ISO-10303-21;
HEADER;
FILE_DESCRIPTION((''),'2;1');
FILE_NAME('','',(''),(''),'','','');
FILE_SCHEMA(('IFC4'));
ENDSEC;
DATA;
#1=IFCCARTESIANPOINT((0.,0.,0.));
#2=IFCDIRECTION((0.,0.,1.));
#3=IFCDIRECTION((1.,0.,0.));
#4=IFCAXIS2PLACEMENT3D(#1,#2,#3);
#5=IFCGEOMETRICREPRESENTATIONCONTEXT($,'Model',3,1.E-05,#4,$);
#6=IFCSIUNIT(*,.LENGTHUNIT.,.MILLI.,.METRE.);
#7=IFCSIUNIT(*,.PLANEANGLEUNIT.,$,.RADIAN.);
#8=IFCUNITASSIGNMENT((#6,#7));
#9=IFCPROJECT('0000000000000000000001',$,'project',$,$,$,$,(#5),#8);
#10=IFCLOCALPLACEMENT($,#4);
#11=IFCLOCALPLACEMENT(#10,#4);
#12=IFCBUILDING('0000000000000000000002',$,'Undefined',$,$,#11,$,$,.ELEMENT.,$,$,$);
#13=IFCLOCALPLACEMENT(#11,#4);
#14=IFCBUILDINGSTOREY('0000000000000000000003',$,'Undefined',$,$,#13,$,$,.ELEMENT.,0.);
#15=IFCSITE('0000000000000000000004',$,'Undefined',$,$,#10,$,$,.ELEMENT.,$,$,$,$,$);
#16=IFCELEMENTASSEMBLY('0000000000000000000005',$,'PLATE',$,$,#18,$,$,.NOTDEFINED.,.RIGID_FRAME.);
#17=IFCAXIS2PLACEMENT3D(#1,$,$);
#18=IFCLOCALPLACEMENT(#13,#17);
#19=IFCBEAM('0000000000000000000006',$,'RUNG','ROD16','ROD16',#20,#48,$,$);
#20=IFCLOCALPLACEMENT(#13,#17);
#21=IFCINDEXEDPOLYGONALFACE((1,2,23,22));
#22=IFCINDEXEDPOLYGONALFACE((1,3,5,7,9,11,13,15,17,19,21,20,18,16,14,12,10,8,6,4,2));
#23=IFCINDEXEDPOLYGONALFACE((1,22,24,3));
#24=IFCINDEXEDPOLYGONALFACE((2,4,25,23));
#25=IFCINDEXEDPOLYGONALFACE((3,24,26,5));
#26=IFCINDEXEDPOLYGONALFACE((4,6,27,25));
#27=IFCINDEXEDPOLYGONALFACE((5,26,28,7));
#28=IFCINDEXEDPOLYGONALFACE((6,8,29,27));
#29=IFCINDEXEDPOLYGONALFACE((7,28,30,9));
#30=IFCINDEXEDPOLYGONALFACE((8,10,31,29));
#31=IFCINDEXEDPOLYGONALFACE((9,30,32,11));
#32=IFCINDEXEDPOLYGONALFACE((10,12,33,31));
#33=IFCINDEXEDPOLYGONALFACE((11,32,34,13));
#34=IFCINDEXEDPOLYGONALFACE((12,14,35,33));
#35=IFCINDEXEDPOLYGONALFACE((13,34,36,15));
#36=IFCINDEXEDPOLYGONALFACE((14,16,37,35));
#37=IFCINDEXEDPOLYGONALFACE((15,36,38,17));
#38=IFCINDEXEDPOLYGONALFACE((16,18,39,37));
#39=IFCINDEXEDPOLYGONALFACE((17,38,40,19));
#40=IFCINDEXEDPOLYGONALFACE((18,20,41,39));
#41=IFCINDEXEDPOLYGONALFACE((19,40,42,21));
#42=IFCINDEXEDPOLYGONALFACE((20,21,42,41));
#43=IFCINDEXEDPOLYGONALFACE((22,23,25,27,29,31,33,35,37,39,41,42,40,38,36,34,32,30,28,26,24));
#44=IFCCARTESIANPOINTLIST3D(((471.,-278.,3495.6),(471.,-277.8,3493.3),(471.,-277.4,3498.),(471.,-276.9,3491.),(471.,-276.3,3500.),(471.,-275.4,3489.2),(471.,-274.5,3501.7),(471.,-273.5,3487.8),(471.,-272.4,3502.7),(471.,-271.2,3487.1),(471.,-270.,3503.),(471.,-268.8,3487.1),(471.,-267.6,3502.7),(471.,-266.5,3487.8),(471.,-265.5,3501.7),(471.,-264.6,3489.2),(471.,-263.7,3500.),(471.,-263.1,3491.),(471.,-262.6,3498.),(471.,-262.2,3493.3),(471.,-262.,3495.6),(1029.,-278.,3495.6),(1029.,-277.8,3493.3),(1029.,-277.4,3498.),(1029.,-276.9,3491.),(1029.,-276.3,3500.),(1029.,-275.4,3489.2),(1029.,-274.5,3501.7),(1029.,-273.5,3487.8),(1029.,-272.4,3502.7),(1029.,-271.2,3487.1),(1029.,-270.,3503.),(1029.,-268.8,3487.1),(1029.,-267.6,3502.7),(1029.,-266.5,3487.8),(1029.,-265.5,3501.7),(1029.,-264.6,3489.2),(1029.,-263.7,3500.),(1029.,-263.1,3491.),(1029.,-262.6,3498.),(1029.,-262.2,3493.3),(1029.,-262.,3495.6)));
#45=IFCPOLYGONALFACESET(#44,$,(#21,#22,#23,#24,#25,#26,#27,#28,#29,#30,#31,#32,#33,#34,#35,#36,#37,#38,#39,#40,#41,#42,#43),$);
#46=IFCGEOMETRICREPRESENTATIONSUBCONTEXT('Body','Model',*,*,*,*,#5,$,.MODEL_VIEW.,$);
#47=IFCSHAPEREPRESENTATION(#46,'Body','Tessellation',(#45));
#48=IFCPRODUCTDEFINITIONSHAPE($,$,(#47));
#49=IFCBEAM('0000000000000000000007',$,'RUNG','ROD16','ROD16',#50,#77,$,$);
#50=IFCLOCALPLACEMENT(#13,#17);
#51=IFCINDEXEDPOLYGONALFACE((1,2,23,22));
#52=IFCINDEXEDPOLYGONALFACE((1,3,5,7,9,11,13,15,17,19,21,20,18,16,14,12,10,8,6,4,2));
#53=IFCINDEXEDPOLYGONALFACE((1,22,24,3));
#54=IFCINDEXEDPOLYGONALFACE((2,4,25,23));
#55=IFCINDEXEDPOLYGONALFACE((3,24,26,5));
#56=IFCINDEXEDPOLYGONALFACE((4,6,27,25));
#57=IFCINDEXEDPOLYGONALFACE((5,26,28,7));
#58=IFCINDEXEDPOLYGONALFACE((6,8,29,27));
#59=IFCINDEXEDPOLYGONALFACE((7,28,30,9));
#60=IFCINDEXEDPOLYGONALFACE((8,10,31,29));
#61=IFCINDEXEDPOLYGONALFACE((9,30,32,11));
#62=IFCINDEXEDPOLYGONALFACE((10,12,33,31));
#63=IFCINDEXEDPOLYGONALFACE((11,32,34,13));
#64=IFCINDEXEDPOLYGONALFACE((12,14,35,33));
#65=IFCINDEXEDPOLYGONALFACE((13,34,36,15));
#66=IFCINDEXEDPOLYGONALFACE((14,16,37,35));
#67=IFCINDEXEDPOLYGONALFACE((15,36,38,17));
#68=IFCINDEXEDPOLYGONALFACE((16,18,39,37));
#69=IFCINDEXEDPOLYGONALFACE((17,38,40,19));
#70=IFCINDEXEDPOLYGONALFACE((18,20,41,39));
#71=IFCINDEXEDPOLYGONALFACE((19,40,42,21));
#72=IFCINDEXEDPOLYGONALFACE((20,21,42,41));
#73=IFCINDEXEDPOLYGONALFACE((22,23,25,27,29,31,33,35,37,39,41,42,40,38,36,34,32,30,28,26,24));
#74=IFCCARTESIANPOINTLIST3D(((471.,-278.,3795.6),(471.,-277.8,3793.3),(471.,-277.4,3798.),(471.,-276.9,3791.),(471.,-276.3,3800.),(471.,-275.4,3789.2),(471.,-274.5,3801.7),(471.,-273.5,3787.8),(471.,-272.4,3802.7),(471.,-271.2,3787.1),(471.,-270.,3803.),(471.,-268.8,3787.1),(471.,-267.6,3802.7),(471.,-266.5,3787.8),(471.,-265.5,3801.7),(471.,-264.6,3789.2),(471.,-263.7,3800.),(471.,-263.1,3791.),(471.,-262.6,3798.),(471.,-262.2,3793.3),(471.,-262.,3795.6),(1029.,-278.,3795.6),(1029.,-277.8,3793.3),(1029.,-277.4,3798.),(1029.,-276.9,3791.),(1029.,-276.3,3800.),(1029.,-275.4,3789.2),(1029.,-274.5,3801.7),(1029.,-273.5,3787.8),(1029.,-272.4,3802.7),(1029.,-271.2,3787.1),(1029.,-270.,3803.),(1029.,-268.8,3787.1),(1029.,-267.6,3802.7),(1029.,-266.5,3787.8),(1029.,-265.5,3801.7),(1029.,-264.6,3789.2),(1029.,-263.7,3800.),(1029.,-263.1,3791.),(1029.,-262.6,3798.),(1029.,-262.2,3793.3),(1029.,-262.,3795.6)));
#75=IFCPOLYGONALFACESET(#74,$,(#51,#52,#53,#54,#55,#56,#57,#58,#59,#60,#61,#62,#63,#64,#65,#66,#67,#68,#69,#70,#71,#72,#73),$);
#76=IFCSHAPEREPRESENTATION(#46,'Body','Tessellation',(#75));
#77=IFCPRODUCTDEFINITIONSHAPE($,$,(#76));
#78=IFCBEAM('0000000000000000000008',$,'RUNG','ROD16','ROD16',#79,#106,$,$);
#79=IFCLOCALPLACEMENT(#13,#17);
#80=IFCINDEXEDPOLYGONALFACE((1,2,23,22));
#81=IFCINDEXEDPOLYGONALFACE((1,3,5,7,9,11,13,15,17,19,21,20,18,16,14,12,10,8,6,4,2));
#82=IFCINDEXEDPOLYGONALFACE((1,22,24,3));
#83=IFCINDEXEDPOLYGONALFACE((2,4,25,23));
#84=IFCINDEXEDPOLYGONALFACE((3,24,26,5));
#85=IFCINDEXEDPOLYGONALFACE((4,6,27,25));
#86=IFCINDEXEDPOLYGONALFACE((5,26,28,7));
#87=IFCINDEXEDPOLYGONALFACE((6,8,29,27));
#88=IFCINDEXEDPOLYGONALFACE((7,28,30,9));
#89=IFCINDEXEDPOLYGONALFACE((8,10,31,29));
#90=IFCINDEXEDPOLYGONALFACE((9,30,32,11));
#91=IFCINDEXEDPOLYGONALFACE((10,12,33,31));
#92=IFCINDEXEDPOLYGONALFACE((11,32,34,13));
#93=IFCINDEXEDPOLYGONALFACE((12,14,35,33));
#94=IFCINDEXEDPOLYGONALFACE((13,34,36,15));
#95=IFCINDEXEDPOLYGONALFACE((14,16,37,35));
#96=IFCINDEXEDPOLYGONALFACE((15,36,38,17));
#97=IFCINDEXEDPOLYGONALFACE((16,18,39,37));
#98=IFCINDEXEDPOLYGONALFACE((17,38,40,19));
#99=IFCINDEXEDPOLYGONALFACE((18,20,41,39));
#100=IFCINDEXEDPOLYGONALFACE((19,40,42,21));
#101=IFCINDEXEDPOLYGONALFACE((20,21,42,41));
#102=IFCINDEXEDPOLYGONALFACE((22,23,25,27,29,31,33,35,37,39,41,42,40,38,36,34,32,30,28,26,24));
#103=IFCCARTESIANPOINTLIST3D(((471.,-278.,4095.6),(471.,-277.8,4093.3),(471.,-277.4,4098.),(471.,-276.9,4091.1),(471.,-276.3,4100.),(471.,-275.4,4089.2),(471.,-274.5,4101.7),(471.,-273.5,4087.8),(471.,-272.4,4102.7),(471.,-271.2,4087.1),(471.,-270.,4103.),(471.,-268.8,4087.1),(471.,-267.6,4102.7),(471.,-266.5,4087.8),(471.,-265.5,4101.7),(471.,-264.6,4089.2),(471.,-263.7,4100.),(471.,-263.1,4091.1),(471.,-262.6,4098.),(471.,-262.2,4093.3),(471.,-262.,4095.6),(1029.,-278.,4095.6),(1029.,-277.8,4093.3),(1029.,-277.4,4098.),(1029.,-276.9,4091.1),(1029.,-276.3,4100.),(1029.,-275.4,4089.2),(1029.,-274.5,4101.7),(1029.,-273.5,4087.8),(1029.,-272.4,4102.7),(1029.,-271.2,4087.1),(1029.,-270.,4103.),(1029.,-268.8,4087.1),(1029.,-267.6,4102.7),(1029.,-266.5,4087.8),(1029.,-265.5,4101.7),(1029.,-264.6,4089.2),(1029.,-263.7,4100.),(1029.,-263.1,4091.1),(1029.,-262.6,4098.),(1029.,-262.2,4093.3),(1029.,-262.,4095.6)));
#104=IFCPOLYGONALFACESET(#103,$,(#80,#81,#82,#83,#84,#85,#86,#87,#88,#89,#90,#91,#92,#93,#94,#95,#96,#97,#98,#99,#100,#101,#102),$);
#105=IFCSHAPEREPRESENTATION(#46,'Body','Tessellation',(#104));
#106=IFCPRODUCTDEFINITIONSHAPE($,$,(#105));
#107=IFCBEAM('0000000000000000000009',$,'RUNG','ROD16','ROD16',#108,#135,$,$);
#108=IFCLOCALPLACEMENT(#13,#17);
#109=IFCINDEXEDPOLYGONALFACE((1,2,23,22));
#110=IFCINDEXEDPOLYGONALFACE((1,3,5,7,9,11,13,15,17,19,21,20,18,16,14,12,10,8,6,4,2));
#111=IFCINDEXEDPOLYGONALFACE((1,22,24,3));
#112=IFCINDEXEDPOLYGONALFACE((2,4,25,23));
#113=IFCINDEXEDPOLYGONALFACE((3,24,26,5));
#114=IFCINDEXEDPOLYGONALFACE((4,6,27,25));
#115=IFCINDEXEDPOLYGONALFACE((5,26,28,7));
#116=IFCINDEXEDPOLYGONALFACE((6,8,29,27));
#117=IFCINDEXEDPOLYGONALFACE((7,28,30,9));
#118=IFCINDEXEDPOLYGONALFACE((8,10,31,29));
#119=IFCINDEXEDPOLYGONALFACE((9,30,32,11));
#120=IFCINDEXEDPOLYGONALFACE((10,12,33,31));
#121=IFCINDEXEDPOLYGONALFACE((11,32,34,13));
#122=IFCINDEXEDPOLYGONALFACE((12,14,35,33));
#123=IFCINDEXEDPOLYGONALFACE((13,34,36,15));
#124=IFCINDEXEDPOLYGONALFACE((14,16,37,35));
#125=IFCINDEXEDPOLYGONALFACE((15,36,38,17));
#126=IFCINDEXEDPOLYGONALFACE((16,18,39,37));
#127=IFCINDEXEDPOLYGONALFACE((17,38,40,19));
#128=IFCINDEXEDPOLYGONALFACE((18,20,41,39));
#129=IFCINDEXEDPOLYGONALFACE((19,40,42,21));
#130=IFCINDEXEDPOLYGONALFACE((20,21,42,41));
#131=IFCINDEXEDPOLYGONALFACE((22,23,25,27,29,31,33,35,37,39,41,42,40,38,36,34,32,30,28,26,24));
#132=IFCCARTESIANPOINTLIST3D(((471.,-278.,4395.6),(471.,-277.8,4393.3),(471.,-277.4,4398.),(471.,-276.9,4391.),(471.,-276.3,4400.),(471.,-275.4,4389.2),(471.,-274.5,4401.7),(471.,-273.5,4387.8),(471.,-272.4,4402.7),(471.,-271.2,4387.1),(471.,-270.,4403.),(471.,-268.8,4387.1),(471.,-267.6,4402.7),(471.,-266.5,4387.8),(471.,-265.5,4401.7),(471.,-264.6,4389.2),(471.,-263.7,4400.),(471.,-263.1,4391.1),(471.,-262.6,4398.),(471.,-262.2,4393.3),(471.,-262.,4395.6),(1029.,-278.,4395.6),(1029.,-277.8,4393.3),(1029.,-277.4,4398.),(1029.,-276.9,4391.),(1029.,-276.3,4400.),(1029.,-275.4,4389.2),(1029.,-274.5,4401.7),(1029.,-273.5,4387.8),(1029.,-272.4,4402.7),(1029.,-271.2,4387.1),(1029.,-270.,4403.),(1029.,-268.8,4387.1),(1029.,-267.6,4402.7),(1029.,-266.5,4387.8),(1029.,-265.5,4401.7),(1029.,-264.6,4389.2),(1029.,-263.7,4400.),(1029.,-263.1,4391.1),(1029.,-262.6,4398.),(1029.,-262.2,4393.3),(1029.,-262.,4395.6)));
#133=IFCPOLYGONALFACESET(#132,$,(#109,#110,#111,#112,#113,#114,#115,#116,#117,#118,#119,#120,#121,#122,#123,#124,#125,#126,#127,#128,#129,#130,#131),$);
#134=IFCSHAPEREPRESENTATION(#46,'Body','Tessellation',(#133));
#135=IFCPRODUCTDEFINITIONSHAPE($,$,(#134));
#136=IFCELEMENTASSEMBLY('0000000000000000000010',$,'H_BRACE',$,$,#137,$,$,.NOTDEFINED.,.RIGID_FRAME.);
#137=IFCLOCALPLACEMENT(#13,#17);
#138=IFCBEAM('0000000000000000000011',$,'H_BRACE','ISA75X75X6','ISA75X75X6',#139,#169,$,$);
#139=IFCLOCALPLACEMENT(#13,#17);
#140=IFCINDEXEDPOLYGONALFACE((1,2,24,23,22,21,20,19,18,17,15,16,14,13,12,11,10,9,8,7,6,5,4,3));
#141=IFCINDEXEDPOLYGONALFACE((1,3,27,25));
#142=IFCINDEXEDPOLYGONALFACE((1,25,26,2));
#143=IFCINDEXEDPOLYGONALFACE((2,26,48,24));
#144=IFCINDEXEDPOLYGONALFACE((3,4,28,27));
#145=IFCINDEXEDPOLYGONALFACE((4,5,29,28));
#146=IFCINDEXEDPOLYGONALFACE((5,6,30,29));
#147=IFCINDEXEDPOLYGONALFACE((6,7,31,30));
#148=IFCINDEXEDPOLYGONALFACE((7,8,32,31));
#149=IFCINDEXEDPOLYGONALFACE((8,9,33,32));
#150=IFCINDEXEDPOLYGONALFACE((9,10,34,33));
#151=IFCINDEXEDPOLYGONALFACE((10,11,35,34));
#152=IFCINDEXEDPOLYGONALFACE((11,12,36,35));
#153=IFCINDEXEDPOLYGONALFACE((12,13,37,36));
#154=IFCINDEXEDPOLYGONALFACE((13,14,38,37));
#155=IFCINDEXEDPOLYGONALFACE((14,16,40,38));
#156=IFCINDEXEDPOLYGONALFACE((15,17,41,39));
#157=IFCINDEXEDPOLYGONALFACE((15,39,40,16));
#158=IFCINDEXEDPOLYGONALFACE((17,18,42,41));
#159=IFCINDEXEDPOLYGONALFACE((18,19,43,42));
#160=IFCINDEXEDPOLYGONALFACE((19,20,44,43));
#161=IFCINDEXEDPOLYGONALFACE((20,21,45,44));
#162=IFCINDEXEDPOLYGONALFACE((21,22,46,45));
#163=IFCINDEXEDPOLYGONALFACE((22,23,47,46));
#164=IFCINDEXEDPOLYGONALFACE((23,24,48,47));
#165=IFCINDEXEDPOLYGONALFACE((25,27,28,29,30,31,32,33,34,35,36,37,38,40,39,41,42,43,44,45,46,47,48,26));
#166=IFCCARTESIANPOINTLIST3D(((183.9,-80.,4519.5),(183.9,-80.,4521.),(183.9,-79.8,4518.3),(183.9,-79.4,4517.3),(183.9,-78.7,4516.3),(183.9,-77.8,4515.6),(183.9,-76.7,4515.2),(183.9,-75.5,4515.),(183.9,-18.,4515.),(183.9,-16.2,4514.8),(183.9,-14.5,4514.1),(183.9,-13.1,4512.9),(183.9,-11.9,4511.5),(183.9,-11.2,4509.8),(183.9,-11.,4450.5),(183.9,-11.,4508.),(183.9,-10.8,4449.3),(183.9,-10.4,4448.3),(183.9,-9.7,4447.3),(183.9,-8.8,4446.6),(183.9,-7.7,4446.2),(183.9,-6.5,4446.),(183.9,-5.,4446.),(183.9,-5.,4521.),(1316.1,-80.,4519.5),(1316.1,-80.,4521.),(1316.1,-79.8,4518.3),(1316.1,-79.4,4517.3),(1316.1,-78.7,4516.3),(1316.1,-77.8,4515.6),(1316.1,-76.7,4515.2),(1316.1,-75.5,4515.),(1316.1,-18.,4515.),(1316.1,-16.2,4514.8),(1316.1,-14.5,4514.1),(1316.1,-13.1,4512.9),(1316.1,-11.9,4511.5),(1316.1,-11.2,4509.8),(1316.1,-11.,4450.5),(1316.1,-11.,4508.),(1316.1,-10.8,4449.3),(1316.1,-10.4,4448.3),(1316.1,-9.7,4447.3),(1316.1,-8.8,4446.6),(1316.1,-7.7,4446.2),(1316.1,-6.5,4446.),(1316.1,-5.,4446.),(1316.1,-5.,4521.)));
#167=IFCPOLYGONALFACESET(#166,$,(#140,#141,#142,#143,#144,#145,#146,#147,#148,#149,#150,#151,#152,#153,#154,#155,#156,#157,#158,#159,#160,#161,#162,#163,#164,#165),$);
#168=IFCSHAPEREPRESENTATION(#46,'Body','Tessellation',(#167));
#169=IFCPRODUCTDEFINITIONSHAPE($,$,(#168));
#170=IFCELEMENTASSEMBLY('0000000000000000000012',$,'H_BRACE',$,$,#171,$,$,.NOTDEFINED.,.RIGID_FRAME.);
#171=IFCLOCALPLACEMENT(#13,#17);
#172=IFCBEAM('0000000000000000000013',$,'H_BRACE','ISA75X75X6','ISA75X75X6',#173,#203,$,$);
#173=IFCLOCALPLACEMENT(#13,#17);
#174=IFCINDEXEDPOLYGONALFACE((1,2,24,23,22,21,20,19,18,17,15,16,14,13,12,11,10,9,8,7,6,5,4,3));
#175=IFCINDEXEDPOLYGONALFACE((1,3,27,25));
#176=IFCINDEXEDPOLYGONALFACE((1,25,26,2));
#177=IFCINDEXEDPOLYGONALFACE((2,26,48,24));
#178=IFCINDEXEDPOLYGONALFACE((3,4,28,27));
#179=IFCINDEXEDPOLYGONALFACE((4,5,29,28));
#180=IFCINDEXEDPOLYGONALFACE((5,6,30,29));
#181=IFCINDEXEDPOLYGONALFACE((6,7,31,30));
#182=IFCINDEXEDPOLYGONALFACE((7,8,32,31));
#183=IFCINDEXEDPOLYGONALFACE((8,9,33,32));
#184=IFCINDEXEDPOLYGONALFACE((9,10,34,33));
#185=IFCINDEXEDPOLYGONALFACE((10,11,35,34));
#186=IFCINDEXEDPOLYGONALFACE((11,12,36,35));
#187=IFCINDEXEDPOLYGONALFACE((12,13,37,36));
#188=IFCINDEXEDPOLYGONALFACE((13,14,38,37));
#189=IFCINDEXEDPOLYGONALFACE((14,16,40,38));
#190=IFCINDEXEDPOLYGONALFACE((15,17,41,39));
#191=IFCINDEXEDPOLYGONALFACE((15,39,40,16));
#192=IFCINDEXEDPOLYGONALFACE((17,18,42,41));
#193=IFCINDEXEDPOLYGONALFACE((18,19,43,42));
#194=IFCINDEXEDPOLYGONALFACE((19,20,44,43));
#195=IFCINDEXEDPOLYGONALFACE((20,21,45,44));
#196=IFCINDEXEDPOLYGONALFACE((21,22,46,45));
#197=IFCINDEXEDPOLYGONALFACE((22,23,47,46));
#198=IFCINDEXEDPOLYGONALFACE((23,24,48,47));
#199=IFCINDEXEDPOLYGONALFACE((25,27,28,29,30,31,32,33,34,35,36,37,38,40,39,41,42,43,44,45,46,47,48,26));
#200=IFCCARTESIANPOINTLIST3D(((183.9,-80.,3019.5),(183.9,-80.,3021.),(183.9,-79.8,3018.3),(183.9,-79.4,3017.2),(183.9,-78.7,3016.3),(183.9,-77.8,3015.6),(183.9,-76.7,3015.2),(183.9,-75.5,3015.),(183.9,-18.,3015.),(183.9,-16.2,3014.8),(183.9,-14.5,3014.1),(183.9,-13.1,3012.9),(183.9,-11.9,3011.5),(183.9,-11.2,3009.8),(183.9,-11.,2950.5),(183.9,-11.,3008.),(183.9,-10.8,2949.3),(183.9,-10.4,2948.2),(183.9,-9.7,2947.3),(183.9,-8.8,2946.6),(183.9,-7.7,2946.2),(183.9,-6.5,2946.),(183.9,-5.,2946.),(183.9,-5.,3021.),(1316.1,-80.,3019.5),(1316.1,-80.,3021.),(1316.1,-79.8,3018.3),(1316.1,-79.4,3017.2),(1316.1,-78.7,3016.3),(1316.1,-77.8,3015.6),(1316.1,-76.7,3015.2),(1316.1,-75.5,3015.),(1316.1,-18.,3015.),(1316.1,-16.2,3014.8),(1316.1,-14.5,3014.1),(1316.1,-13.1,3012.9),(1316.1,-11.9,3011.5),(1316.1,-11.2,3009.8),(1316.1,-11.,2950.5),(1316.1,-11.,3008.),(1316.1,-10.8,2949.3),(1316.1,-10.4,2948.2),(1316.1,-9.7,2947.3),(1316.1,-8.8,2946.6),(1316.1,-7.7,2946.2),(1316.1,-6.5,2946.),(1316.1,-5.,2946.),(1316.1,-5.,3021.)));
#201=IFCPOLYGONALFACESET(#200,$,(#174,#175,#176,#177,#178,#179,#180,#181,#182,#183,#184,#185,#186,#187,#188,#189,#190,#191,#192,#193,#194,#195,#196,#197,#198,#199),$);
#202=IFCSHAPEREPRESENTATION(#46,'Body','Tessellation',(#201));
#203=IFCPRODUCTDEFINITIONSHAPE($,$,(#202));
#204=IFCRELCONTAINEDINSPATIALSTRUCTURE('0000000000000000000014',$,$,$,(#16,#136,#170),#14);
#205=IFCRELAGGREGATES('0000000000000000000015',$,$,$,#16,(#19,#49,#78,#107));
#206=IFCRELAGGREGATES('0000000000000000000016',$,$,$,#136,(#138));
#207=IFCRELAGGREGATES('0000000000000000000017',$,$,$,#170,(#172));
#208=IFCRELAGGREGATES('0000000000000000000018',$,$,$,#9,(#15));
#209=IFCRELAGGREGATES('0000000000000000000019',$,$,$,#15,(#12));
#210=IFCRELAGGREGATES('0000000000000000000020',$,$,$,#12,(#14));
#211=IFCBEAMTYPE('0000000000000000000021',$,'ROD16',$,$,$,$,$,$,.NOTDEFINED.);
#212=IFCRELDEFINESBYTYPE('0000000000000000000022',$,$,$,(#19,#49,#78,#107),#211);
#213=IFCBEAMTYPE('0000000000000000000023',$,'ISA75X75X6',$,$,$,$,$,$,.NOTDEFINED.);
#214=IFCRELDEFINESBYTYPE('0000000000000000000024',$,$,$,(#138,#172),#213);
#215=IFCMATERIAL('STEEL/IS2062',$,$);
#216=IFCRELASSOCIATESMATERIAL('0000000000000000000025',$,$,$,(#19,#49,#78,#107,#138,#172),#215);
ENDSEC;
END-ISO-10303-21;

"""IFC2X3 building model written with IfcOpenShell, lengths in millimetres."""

from ifc_helpers import new_model, si_unit, frame, origin_with_axes, origin_2d_with_axis, place, context, subcontext, project, spatial, circle, l_section, extrude, clip, halfspace, material, type_object, element, aggregate, save


model = new_model("IFC2X3")

# Units and contexts
model_context = context("Model", 3, precision=1e-05, world=origin_with_axes())
body_context = subcontext(model_context, "Body", "Model", "MODEL_VIEW")
ifc_project = project(units=[si_unit("LENGTHUNIT", "METRE", prefix="MILLI"), si_unit("PLANEANGLEUNIT", "RADIAN")], contexts=[model_context])

# Site, building, storey
site_placement = place(None, origin_with_axes())
site = spatial("IfcSite", under=ifc_project, at=site_placement, Name="Undefined", CompositionType="ELEMENT")
building_placement = place(site_placement, origin_with_axes())
building = spatial("IfcBuilding", under=site, at=building_placement, Name="Undefined", CompositionType="ELEMENT")
storey_placement = place(building_placement, origin_with_axes())
storey = spatial("IfcBuildingStorey", under=building, at=storey_placement, Name="Undefined", CompositionType="ELEMENT", Elevation=0.0)

# Shared definitions
ifc_material = material(Name="STEEL/IS2062")

# Element assembly, beams
assembly_1_placement = place(storey_placement, origin_with_axes())
assembly_1 = element("IfcElementAssembly", 1, at=assembly_1_placement, inside=storey, Name="PLATE", AssemblyPlace="NOTDEFINED", PredefinedType="RIGID_FRAME")
beam_type_1 = type_object("IfcBeamType", Name="ROD16", PredefinedType="NOTDEFINED")
beam_1_placement = place(assembly_1_placement, frame((471.0, -270.0, 3495.1), z_axis=(0.0, 1.0, 0.0), x_axis=(1.0, 0.0, 0.0)))
beam_1 = element("IfcBeam", 2, at=beam_1_placement, type_object=beam_type_1, material=ifc_material, Name="RUNG", Description="ROD16", ObjectType="ROD16", context=body_context, shape_type="SweptSolid", body=[
    extrude(circle(Radius=8.0, at=origin_2d_with_axis()), frame((558.0, 0.0, 0.0), z_axis=(-1.0, 0.0, 0.0), x_axis=(0.0, -1.0, 0.0)), (0.0, 0.0, 1.0), 558.0),
])
beam_2_placement = place(assembly_1_placement, frame((471.0, -270.0, 3795.1), z_axis=(0.0, 1.0, 0.0), x_axis=(1.0, 0.0, 0.0)))
beam_2 = element("IfcBeam", 3, at=beam_2_placement, type_object=beam_type_1, material=ifc_material, Name="RUNG", Description="ROD16", ObjectType="ROD16", context=body_context, shape_type="SweptSolid", body=[
    extrude(circle(Radius=8.0, at=origin_2d_with_axis()), frame((558.0, 0.0, 0.0), z_axis=(-1.0, 0.0, 0.0), x_axis=(0.0, -1.0, 0.0)), (0.0, 0.0, 1.0), 558.0),
])
beam_3_placement = place(assembly_1_placement, frame((471.0, -270.0, 4095.1), z_axis=(0.0, 1.0, 0.0), x_axis=(1.0, 0.0, 0.0)))
beam_3 = element("IfcBeam", 4, at=beam_3_placement, type_object=beam_type_1, material=ifc_material, Name="RUNG", Description="ROD16", ObjectType="ROD16", context=body_context, shape_type="SweptSolid", body=[
    extrude(circle(Radius=8.0, at=origin_2d_with_axis()), frame((558.0, 0.0, 0.0), z_axis=(-1.0, 0.0, 0.0), x_axis=(0.0, -1.0, 0.0)), (0.0, 0.0, 1.0), 558.0),
])
beam_4_placement = place(assembly_1_placement, frame((471.0, -270.0, 4395.1), z_axis=(0.0, 1.0, 0.0), x_axis=(1.0, 0.0, 0.0)))
beam_4 = element("IfcBeam", 5, at=beam_4_placement, type_object=beam_type_1, material=ifc_material, Name="RUNG", Description="ROD16", ObjectType="ROD16", context=body_context, shape_type="SweptSolid", body=[
    extrude(circle(Radius=8.0, at=origin_2d_with_axis()), frame((558.0, 0.0, 0.0), z_axis=(-1.0, 0.0, 0.0), x_axis=(0.0, -1.0, 0.0)), (0.0, 0.0, 1.0), 558.0),
])
aggregate(assembly_1, [beam_1, beam_2, beam_3, beam_4])

# Element assemblies, beams
beam_type_2 = type_object("IfcBeamType", Name="ISA75X75X6", PredefinedType="NOTDEFINED")
assembly_2_placement = place(storey_placement, origin_with_axes())
assembly_2 = element("IfcElementAssembly", 6, at=assembly_2_placement, inside=storey, Name="H_BRACE", AssemblyPlace="NOTDEFINED", PredefinedType="RIGID_FRAME")
beam_5_placement = place(assembly_2_placement, frame((0.0, -42.5, 4483.5), z_axis=(0.0, -1.0, 0.0), x_axis=(1.0, 0.0, 0.0)))
beam_5 = element("IfcBeam", 7, at=beam_5_placement, type_object=beam_type_2, material=ifc_material, Name="H_BRACE", Description="ISA75X75X6", ObjectType="ISA75X75X6", context=body_context, shape_type="Clipping", body=[
    clip(clip(extrude(l_section(Depth=75.0, Width=75.0, Thickness=6.0, FilletRadius=7.0, EdgeRadius=4.5, at=origin_2d_with_axis()), frame((1500.0, 0.0, 0.0), z_axis=(-1.0, 0.0, 0.0), x_axis=(0.0, -1.0, 0.0)), (0.0, 0.0, 1.0), 1500.0), halfspace(frame((1316.1, 0.0, -37.5), z_axis=(-1.0, 0.0, 0.0), x_axis=(0.0, -1.0, 0.0)), True)), halfspace(frame((183.9, 0.0, -37.5), z_axis=(1.0, 0.0, 0.0), x_axis=(0.0, 1.0, 0.0)), True)),
])
aggregate(assembly_2, [beam_5])
assembly_3_placement = place(storey_placement, origin_with_axes())
assembly_3 = element("IfcElementAssembly", 8, at=assembly_3_placement, inside=storey, Name="H_BRACE", AssemblyPlace="NOTDEFINED", PredefinedType="RIGID_FRAME")
beam_6_placement = place(assembly_3_placement, frame((0.0, -42.5, 2983.5), z_axis=(0.0, -1.0, 0.0), x_axis=(1.0, 0.0, 0.0)))
beam_6 = element("IfcBeam", 9, at=beam_6_placement, type_object=beam_type_2, material=ifc_material, Name="H_BRACE", Description="ISA75X75X6", ObjectType="ISA75X75X6", context=body_context, shape_type="Clipping", body=[
    clip(clip(extrude(l_section(Depth=75.0, Width=75.0, Thickness=6.0, FilletRadius=7.0, EdgeRadius=4.5, at=origin_2d_with_axis()), frame((1500.0, 0.0, 0.0), z_axis=(-1.0, 0.0, 0.0), x_axis=(0.0, -1.0, 0.0)), (0.0, 0.0, 1.0), 1500.0), halfspace(frame((1316.1, 0.0, -37.5), z_axis=(-1.0, 0.0, 0.0), x_axis=(0.0, -1.0, 0.0)), True)), halfspace(frame((183.9, 0.0, -37.5), z_axis=(1.0, 0.0, 0.0), x_axis=(0.0, 1.0, 0.0)), True)),
])
aggregate(assembly_3, [beam_6])

save(model, "model.ifc")
